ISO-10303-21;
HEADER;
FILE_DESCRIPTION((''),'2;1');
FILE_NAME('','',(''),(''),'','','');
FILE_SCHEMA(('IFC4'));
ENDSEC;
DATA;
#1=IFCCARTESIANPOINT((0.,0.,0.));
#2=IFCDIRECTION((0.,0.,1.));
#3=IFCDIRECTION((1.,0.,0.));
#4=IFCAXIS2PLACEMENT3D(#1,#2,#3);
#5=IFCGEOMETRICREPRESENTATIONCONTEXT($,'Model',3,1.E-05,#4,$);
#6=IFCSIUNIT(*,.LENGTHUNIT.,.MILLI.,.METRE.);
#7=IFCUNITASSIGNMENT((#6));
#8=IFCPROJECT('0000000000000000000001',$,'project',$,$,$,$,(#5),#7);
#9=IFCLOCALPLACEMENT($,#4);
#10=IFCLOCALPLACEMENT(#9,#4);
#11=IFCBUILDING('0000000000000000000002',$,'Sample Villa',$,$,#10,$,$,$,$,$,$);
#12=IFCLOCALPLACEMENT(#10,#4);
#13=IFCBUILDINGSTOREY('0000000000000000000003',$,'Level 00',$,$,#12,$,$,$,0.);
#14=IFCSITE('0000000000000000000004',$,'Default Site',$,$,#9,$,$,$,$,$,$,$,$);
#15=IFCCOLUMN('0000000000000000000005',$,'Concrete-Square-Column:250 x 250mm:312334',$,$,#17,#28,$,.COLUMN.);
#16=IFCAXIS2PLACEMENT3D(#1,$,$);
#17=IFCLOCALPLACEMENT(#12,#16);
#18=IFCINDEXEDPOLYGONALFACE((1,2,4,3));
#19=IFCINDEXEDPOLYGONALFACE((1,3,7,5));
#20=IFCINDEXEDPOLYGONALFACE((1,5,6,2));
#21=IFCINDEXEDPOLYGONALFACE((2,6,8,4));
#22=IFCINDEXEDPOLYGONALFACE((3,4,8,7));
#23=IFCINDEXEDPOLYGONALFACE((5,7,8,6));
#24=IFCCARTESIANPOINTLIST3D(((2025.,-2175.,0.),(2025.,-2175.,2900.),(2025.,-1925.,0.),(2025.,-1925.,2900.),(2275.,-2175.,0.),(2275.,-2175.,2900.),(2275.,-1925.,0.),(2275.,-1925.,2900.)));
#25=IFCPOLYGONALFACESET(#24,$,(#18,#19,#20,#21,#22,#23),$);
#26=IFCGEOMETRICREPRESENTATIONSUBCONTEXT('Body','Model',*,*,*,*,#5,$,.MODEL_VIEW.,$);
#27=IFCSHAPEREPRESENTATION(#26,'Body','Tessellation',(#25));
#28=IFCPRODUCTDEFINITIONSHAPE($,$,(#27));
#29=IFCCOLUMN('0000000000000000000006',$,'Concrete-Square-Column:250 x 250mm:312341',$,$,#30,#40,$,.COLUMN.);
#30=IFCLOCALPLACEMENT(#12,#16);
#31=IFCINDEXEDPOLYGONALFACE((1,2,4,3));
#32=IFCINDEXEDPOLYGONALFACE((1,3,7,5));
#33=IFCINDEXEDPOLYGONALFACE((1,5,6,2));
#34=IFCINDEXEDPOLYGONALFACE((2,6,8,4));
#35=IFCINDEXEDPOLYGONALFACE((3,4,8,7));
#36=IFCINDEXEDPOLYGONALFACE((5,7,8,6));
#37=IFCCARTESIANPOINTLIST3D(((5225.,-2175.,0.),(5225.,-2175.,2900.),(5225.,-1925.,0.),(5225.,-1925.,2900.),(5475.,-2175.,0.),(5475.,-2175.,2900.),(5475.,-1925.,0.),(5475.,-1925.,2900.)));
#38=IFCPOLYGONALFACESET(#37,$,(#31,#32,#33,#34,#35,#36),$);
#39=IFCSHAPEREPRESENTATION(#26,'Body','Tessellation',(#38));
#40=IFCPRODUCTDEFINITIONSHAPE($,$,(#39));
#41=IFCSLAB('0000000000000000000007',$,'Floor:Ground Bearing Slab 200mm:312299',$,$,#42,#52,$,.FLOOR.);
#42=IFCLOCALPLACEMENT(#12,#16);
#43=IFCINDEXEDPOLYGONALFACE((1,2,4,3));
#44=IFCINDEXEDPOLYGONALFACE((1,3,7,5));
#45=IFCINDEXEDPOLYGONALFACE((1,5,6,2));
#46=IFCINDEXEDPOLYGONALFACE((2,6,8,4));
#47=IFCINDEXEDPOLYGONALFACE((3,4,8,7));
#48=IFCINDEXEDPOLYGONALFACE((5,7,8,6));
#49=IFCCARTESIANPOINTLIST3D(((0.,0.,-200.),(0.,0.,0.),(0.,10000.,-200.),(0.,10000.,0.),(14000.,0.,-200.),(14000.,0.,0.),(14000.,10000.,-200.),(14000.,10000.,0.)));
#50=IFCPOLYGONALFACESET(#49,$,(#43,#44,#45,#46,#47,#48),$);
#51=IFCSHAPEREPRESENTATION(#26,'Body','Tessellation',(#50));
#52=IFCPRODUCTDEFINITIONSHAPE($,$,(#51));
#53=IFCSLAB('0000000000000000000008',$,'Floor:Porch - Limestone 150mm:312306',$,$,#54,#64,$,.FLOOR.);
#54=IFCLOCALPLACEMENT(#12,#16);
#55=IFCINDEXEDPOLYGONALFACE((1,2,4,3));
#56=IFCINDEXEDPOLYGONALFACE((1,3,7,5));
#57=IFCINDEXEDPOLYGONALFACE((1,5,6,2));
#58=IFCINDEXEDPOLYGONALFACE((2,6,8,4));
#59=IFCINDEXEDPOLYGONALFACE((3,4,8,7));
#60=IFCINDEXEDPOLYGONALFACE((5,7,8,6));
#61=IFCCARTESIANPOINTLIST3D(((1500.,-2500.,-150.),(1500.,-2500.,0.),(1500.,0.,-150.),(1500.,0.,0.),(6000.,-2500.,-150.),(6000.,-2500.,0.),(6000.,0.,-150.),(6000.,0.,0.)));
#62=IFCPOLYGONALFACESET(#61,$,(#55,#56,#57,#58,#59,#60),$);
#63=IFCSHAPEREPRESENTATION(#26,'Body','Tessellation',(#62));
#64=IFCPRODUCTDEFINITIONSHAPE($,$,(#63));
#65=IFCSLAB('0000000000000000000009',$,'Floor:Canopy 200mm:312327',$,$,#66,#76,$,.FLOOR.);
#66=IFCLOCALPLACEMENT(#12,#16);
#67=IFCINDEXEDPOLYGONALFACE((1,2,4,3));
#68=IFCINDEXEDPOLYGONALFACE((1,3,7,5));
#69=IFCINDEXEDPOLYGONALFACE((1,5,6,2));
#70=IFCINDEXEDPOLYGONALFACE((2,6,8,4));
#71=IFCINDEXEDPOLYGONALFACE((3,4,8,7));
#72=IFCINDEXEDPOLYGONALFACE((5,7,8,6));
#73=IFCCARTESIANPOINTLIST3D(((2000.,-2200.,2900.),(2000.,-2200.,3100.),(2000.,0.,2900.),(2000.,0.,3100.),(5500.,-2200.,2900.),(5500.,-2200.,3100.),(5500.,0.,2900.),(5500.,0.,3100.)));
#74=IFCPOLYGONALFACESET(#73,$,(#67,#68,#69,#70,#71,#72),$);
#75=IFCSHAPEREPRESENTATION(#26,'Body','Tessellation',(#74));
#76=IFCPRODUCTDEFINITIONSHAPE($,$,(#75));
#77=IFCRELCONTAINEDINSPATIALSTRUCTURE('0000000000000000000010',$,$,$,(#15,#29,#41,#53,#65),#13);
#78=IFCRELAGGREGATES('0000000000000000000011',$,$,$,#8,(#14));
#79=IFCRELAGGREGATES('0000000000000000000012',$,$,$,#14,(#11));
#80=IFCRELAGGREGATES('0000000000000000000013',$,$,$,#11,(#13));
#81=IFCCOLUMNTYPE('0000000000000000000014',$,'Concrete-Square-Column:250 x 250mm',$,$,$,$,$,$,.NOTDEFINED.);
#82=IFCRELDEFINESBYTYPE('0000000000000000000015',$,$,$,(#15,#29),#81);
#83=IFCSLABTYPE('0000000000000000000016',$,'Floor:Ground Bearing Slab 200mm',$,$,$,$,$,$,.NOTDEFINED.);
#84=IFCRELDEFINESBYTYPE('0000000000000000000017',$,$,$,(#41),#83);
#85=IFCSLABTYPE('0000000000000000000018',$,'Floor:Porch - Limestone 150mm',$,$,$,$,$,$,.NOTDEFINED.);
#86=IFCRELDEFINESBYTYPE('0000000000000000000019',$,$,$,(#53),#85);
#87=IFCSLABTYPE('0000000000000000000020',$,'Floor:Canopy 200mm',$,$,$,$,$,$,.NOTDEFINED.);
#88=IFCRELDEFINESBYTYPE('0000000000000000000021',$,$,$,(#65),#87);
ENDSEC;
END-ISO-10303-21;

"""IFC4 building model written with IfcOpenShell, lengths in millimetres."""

from ifc_helpers import new_model, si_unit, frame, frame_2d, origin_with_axes, place, context, subcontext, project, spatial, rectangle, extrude, type_object, element, save


model = new_model("IFC4")

# Units and contexts
model_context = context("Model", 3, precision=1e-05, world=origin_with_axes())
body_context = subcontext(model_context, "Body", "Model", "MODEL_VIEW")
ifc_project = project(units=[si_unit("LENGTHUNIT", "METRE", prefix="MILLI")], contexts=[model_context])

# Site, building, storey
site_placement = place(None, origin_with_axes())
site = spatial("IfcSite", under=ifc_project, at=site_placement, Name="Default Site")
building_placement = place(site_placement, origin_with_axes())
building = spatial("IfcBuilding", under=site, at=building_placement, Name="Sample Villa")
storey_placement = place(building_placement, origin_with_axes())
storey = spatial("IfcBuildingStorey", under=building, at=storey_placement, Name="Level 00", Elevation=0.0)

# Columns
column_type = type_object("IfcColumnType", Name="Concrete-Square-Column:250 x 250mm", PredefinedType="NOTDEFINED")
column_1_placement = place(storey_placement, origin_with_axes())
element("IfcColumn", 1, at=column_1_placement, inside=storey, type_object=column_type, Name="Concrete-Square-Column:250 x 250mm:312334", PredefinedType="COLUMN", context=body_context, shape_type="SweptSolid", body=[
    extrude(rectangle(XDim=250.0, YDim=250.0, at=frame_2d((125.0, 125.0))), frame((2025.0, -2175.0, 0.0)), (0.0, 0.0, 1.0), 2900.0),
])
column_2_placement = place(storey_placement, origin_with_axes())
element("IfcColumn", 2, at=column_2_placement, inside=storey, type_object=column_type, Name="Concrete-Square-Column:250 x 250mm:312341", PredefinedType="COLUMN", context=body_context, shape_type="SweptSolid", body=[
    extrude(rectangle(XDim=250.0, YDim=250.0, at=frame_2d((125.0, 125.0))), frame((5225.0, -2175.0, 0.0)), (0.0, 0.0, 1.0), 2900.0),
])

# Slabs
slab_type_1 = type_object("IfcSlabType", Name="Floor:Ground Bearing Slab 200mm", PredefinedType="NOTDEFINED")
slab_1_placement = place(storey_placement, origin_with_axes())
element("IfcSlab", 3, at=slab_1_placement, inside=storey, type_object=slab_type_1, Name="Floor:Ground Bearing Slab 200mm:312299", PredefinedType="FLOOR", context=body_context, shape_type="SweptSolid", body=[
    extrude(rectangle(XDim=14000.0, YDim=10000.0, at=frame_2d((7000.0, 5000.0))), frame((0.0, 0.0, -200.0)), (0.0, 0.0, 1.0), 200.0),
])
slab_type_2 = type_object("IfcSlabType", Name="Floor:Porch - Limestone 150mm", PredefinedType="NOTDEFINED")
slab_2_placement = place(storey_placement, origin_with_axes())
element("IfcSlab", 4, at=slab_2_placement, inside=storey, type_object=slab_type_2, Name="Floor:Porch - Limestone 150mm:312306", PredefinedType="FLOOR", context=body_context, shape_type="SweptSolid", body=[
    extrude(rectangle(XDim=4500.0, YDim=2500.0, at=frame_2d((2250.0, 1250.0))), frame((1500.0, -2500.0, -150.0)), (0.0, 0.0, 1.0), 150.0),
])
slab_type_3 = type_object("IfcSlabType", Name="Floor:Canopy 200mm", PredefinedType="NOTDEFINED")
slab_3_placement = place(storey_placement, origin_with_axes())
element("IfcSlab", 5, at=slab_3_placement, inside=storey, type_object=slab_type_3, Name="Floor:Canopy 200mm:312327", PredefinedType="FLOOR", context=body_context, shape_type="SweptSolid", body=[
    extrude(rectangle(XDim=3500.0, YDim=2200.0, at=frame_2d((1750.0, 1100.0))), frame((2000.0, -2200.0, 2900.0)), (0.0, 0.0, 1.0), 200.0),
])

save(model, "model.ifc")
